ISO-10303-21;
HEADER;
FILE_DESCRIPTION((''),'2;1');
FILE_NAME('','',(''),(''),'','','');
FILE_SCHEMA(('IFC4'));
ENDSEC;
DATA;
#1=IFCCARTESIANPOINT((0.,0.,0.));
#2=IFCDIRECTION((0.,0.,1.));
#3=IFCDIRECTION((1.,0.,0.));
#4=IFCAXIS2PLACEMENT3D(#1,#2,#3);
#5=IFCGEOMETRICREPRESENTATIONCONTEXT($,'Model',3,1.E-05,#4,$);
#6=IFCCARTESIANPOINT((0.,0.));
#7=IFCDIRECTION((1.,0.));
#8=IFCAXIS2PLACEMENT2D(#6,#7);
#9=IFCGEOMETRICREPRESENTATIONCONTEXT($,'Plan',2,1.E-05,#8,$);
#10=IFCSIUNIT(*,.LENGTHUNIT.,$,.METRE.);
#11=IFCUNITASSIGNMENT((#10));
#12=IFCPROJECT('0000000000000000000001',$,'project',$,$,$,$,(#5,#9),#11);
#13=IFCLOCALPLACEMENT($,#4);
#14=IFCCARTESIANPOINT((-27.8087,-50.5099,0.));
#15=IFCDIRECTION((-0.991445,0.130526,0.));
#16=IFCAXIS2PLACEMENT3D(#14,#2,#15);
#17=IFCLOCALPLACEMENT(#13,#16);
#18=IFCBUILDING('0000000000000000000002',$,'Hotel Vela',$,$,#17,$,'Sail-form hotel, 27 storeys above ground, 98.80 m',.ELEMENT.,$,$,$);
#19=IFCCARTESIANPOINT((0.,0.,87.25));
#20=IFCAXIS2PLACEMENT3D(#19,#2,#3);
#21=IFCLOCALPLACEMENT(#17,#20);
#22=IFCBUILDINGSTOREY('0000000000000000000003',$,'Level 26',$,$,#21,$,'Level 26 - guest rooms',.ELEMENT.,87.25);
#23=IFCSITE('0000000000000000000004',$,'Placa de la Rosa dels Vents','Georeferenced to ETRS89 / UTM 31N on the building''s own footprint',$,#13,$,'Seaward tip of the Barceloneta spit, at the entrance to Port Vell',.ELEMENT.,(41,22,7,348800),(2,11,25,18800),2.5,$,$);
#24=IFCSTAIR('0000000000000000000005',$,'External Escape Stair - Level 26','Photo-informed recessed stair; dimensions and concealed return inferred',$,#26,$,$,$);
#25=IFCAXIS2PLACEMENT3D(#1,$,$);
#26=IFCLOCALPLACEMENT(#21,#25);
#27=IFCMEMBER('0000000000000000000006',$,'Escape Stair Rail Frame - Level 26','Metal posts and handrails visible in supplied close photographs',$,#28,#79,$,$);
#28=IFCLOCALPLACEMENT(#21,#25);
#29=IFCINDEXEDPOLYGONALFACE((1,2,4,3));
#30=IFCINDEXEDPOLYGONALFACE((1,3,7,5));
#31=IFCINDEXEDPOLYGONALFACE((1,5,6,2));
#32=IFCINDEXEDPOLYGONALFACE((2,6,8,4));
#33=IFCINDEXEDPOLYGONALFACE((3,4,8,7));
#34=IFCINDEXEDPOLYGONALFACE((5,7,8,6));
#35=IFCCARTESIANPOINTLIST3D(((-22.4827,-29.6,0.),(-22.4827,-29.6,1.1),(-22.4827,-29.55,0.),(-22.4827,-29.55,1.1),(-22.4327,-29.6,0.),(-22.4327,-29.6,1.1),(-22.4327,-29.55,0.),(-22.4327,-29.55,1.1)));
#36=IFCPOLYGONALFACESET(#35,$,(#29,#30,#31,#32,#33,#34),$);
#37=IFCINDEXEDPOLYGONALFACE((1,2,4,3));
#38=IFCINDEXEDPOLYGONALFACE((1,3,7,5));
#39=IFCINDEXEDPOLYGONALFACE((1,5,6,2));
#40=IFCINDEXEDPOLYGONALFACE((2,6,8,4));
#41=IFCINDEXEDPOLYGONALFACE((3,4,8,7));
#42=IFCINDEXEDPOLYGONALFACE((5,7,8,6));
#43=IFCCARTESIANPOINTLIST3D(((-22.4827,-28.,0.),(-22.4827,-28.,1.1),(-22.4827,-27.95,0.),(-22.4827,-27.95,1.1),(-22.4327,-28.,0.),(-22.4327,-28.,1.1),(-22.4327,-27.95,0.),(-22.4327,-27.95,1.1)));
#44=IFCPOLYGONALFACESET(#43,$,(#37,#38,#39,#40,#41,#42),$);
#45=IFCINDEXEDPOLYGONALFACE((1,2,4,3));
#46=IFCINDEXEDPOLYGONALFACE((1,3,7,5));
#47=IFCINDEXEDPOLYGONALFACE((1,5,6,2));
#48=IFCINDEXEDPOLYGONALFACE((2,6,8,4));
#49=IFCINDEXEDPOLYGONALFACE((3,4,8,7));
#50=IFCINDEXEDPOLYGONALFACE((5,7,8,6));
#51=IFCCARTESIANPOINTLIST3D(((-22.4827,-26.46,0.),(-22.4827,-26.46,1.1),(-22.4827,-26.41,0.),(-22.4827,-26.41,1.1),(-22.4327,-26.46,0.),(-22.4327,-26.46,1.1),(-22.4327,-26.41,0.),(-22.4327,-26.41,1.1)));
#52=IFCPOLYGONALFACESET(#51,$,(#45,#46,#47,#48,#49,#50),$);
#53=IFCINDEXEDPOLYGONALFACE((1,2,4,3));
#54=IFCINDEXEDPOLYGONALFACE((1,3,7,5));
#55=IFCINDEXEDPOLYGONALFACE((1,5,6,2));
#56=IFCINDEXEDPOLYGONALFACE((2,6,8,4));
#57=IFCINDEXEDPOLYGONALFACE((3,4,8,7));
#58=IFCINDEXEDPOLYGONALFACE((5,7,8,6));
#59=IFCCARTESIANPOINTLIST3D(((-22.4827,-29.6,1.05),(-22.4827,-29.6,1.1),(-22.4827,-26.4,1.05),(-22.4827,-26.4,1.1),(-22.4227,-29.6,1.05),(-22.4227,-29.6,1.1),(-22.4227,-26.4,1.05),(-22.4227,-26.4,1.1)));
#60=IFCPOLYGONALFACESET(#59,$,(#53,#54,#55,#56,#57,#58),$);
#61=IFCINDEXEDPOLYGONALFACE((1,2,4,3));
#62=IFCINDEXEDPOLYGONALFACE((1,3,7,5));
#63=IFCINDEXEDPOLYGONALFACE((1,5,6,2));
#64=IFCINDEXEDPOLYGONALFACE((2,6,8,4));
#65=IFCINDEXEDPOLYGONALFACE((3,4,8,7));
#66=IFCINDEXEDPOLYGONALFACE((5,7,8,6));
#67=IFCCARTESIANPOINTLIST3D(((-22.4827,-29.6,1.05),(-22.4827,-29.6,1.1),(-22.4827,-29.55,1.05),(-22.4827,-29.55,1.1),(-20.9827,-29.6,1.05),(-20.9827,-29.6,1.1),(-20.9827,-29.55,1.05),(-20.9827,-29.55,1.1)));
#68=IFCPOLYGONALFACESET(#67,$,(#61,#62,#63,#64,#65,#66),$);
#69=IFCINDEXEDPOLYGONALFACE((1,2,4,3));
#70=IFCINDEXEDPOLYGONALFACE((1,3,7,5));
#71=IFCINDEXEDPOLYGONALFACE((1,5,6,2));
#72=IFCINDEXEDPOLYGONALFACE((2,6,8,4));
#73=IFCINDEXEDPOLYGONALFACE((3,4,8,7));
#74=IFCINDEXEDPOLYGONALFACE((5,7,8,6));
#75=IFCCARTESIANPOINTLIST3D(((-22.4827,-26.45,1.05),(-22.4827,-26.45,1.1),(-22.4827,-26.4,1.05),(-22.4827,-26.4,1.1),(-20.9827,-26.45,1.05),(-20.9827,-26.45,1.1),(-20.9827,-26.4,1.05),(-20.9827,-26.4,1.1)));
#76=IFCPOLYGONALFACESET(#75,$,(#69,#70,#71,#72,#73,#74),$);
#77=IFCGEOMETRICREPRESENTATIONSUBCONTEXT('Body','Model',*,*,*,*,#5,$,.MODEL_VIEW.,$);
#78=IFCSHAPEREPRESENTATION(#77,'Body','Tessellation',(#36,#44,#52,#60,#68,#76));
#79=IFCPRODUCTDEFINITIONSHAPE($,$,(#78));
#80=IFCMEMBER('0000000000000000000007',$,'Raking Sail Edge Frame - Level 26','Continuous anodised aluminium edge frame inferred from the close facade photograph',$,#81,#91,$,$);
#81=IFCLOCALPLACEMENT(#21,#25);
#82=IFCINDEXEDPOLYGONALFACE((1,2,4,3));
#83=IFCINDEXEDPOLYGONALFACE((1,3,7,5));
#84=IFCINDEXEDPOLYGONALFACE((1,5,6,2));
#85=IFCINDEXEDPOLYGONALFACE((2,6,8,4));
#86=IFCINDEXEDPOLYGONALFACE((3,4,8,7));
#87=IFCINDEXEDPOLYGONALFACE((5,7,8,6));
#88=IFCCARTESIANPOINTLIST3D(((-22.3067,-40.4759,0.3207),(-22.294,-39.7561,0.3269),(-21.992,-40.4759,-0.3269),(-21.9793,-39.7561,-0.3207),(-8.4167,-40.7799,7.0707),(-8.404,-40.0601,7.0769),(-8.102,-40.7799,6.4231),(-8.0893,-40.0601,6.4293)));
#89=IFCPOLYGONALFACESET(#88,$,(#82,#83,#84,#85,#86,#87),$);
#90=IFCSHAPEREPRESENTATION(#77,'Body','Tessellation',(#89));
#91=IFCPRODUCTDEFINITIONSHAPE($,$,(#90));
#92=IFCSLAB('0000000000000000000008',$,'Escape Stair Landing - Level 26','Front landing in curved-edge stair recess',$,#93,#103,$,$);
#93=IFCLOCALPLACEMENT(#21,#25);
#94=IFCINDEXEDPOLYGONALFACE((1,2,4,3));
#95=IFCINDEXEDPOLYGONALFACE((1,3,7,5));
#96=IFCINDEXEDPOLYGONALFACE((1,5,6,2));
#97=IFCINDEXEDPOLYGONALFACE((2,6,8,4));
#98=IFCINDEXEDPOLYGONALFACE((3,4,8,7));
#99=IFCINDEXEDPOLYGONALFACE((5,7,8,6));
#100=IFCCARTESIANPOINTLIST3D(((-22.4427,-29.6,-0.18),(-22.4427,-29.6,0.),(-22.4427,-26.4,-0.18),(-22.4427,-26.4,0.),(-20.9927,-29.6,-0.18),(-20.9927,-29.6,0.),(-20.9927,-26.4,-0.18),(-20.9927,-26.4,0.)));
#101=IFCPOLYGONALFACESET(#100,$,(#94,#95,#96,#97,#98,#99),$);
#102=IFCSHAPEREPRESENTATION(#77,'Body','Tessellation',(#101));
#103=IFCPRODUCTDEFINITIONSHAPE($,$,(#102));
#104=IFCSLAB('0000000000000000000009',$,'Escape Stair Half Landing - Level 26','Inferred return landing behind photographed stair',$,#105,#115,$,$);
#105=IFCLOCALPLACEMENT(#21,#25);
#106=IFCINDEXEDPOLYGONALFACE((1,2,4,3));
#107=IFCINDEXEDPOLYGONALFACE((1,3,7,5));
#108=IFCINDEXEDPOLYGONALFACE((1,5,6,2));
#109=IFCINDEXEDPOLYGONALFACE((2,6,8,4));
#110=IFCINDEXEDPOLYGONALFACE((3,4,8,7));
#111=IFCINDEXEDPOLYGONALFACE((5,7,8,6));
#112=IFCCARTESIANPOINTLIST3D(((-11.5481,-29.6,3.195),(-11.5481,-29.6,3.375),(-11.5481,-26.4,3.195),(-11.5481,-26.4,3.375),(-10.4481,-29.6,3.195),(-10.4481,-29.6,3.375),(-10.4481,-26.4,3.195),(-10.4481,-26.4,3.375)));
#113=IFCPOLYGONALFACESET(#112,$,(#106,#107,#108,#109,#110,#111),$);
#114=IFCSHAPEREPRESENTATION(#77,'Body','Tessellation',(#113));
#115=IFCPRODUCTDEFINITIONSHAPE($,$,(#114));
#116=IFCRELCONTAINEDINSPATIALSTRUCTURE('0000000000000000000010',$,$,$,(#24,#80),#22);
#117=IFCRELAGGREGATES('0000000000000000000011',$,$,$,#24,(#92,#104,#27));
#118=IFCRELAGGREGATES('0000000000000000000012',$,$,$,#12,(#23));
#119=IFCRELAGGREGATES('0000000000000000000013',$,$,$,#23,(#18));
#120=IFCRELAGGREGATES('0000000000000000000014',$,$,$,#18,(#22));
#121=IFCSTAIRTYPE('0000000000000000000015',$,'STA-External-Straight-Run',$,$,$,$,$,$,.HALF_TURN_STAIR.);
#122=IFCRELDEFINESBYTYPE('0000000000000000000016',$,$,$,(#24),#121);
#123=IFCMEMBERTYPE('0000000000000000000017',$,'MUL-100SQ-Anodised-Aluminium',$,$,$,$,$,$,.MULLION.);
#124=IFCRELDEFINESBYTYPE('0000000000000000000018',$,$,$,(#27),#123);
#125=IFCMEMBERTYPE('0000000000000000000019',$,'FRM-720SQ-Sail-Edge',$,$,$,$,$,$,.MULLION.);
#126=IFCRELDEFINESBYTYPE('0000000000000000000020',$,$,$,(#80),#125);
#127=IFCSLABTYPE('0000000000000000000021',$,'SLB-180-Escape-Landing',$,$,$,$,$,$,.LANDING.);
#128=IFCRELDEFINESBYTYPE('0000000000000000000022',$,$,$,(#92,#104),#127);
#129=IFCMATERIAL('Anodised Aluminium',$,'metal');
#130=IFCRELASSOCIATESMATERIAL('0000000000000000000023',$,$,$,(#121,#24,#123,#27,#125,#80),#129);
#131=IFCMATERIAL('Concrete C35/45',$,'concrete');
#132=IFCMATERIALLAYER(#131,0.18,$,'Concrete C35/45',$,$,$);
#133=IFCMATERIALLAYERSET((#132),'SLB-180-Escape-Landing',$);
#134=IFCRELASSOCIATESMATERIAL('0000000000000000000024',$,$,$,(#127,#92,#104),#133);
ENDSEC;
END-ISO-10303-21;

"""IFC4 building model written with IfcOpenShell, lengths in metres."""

from ifc_helpers import new_model, si_unit, frame, origin_with_axes, origin_2d_with_axis, place, context, subcontext, project, spatial, line, indexed_curve, rectangle, outline, extrude, material, layer, layer_set, layer_usage, material_profile, profile_set, profile_usage, type_object, element, aggregate, save


model = new_model("IFC4")

# Units and contexts
model_context = context("Model", 3, precision=1e-05, world=origin_with_axes())
plan_context = context("Plan", 2, precision=1e-05, world=origin_2d_with_axis())
body_context = subcontext(model_context, "Body", "Model", "MODEL_VIEW")
ifc_project = project(units=[si_unit("LENGTHUNIT", "METRE")], contexts=[model_context, plan_context])

# Site, building, storey
site_placement = place(None, origin_with_axes())
site = spatial("IfcSite", under=ifc_project, at=site_placement, Name="Placa de la Rosa dels Vents", Description="Georeferenced to ETRS89 / UTM 31N on the building's own footprint", LongName="Seaward tip of the Barceloneta spit, at the entrance to Port Vell", CompositionType="ELEMENT", RefLatitude=(41, 22, 7, 348800), RefLongitude=(2, 11, 25, 18800), RefElevation=2.5)
building_placement = place(site_placement, frame((-27.8087, -50.5099, 0.0), z_axis=(0.0, 0.0, 1.0), x_axis=(-0.991445, 0.130526, 0.0)))
building = spatial("IfcBuilding", under=site, at=building_placement, Name="Hotel Vela", LongName="Sail-form hotel, 27 storeys above ground, 98.80 m", CompositionType="ELEMENT")
storey_placement = place(building_placement, frame((0.0, 0.0, 87.25), z_axis=(0.0, 0.0, 1.0), x_axis=(1.0, 0.0, 0.0)))
storey = spatial("IfcBuildingStorey", under=building, at=storey_placement, Name="Level 26", LongName="Level 26 - guest rooms", CompositionType="ELEMENT", Elevation=87.25)

# Stair, member
ifc_material_1 = material(Name="Anodised Aluminium", Category="metal")
stair_type = type_object("IfcStairType", Name="STA-External-Straight-Run", PredefinedType="HALF_TURN_STAIR", material=ifc_material_1)
stair_placement = place(storey_placement, frame((0.0, 0.0, -87.25), z_axis=(0.0, 0.0, 1.0), x_axis=(1.0, 0.0, 0.0)))
stair = element("IfcStair", 1, at=stair_placement, inside=storey, type_object=stair_type, material=ifc_material_1, Name="External Escape Stair - Level 26", Description="Photo-informed recessed stair; dimensions and concealed return inferred")
ifc_material_profile_1 = material_profile(ifc_material_1, rectangle(XDim=0.1, YDim=0.1))
ifc_profile_set_1 = profile_set([ifc_material_profile_1], Name="MUL-100SQ-Anodised-Aluminium")
ifc_profile_usage_1 = profile_usage(ifc_profile_set_1)
member_type_1 = type_object("IfcMemberType", Name="MUL-100SQ-Anodised-Aluminium", PredefinedType="MULLION", material=ifc_profile_set_1)
member_1_placement = place(stair_placement, origin_with_axes())
member_1 = element("IfcMember", 2, at=member_1_placement, type_object=member_type_1, material=ifc_profile_usage_1, Name="Escape Stair Rail Frame - Level 26", Description="Metal posts and handrails visible in supplied close photographs", context=body_context, shape_type="SweptSolid", body=[
    extrude(outline(indexed_curve([(0.0, 0.0), (0.05, 0.0), (0.05, 0.05), (0.0, 0.05)], segments=[line(1, 2, 3, 4, 1)])), frame((-22.4827, -29.6, 87.25), z_axis=(0.0, 0.0, 1.0), x_axis=(1.0, 0.0, 0.0)), (0.0, 0.0, 1.0), 1.1),
    extrude(outline(indexed_curve([(0.0, 0.0), (0.05, 0.0), (0.05, 0.05), (0.0, 0.05)], segments=[line(1, 2, 3, 4, 1)])), frame((-22.4827, -28.0, 87.25), z_axis=(0.0, 0.0, 1.0), x_axis=(1.0, 0.0, 0.0)), (0.0, 0.0, 1.0), 1.1),
    extrude(outline(indexed_curve([(0.0, 0.0), (0.05, 0.0), (0.05, 0.05), (0.0, 0.05)], segments=[line(1, 2, 3, 4, 1)])), frame((-22.4827, -26.46, 87.25), z_axis=(0.0, 0.0, 1.0), x_axis=(1.0, 0.0, 0.0)), (0.0, 0.0, 1.0), 1.1),
    extrude(outline(indexed_curve([(0.0, 0.0), (0.06, 0.0), (0.06, 3.2), (0.0, 3.2)], segments=[line(1, 2, 3, 4, 1)])), frame((-22.4827, -29.6, 88.3), z_axis=(0.0, 0.0, 1.0), x_axis=(1.0, 0.0, 0.0)), (0.0, 0.0, 1.0), 0.05),
    extrude(outline(indexed_curve([(0.0, 0.0), (1.5, 0.0), (1.5, 0.05), (0.0, 0.05)], segments=[line(1, 2, 3, 4, 1)])), frame((-22.4827, -29.6, 88.3), z_axis=(0.0, 0.0, 1.0), x_axis=(1.0, 0.0, 0.0)), (0.0, 0.0, 1.0), 0.05),
    extrude(outline(indexed_curve([(0.0, 0.0), (1.5, 0.0), (1.5, 0.05), (0.0, 0.05)], segments=[line(1, 2, 3, 4, 1)])), frame((-22.4827, -26.45, 88.3), z_axis=(0.0, 0.0, 1.0), x_axis=(1.0, 0.0, 0.0)), (0.0, 0.0, 1.0), 0.05),
])

# Member
ifc_material_profile_2 = material_profile(ifc_material_1, rectangle(XDim=0.72, YDim=0.72))
ifc_profile_set_2 = profile_set([ifc_material_profile_2], Name="FRM-720SQ-Sail-Edge")
ifc_profile_usage_2 = profile_usage(ifc_profile_set_2)
member_type_2 = type_object("IfcMemberType", Name="FRM-720SQ-Sail-Edge", PredefinedType="MULLION", material=ifc_profile_set_2)
member_2_placement = place(storey_placement, frame((-22.143, -40.116, 0.0), z_axis=(0.899247, -0.019681, 0.436999), x_axis=(0.437084, 0.0, -0.899421)))
element("IfcMember", 3, at=member_2_placement, inside=storey, type_object=member_type_2, material=ifc_profile_usage_2, Name="Raking Sail Edge Frame - Level 26", Description="Continuous anodised aluminium edge frame inferred from the close facade photograph", context=body_context, shape_type="SweptSolid", body=[
    extrude(outline(indexed_curve([(-0.36, -0.36), (0.36, -0.36), (0.36, 0.36), (-0.36, 0.36)], segments=[line(1, 2, 3, 4, 1)])), origin_with_axes(), (0.0, 0.0, 1.0), 15.4463),
])

# Slabs
ifc_material_2 = material(Name="Concrete C35/45", Category="concrete")
ifc_layer = layer(ifc_material_2, 0.18, Name="Concrete C35/45")
ifc_layer_set = layer_set([ifc_layer], Name="SLB-180-Escape-Landing")
ifc_layer_usage_1 = layer_usage(ifc_layer_set, "AXIS3", "POSITIVE", 0.0)
slab_type = type_object("IfcSlabType", Name="SLB-180-Escape-Landing", PredefinedType="LANDING", material=ifc_layer_set)
slab_1_placement = place(stair_placement, frame((-22.4427, -29.6, 87.07), z_axis=(0.0, 0.0, 1.0), x_axis=(1.0, 0.0, 0.0)))
slab_1 = element("IfcSlab", 4, at=slab_1_placement, type_object=slab_type, material=ifc_layer_usage_1, Name="Escape Stair Landing - Level 26", Description="Front landing in curved-edge stair recess", context=body_context, shape_type="SweptSolid", body=[
    extrude(outline(indexed_curve([(0.0, 0.0), (1.45, 0.0), (1.45, 3.2), (0.0, 3.2)], segments=[line(1, 2, 3, 4, 1)])), origin_with_axes(), (0.0, 0.0, 1.0), 0.18),
])
ifc_layer_usage_2 = layer_usage(ifc_layer_set, "AXIS3", "POSITIVE", 0.0)
slab_2_placement = place(stair_placement, frame((-11.5481, -29.6, 90.445), z_axis=(0.0, 0.0, 1.0), x_axis=(1.0, 0.0, 0.0)))
slab_2 = element("IfcSlab", 5, at=slab_2_placement, type_object=slab_type, material=ifc_layer_usage_2, Name="Escape Stair Half Landing - Level 26", Description="Inferred return landing behind photographed stair", context=body_context, shape_type="SweptSolid", body=[
    extrude(outline(indexed_curve([(0.0, 0.0), (1.1, 0.0), (1.1, 3.2), (0.0, 3.2)], segments=[line(1, 2, 3, 4, 1)])), origin_with_axes(), (0.0, 0.0, 1.0), 0.18),
])

aggregate(stair, [slab_1, slab_2, member_1])

save(model, "model.ifc")
